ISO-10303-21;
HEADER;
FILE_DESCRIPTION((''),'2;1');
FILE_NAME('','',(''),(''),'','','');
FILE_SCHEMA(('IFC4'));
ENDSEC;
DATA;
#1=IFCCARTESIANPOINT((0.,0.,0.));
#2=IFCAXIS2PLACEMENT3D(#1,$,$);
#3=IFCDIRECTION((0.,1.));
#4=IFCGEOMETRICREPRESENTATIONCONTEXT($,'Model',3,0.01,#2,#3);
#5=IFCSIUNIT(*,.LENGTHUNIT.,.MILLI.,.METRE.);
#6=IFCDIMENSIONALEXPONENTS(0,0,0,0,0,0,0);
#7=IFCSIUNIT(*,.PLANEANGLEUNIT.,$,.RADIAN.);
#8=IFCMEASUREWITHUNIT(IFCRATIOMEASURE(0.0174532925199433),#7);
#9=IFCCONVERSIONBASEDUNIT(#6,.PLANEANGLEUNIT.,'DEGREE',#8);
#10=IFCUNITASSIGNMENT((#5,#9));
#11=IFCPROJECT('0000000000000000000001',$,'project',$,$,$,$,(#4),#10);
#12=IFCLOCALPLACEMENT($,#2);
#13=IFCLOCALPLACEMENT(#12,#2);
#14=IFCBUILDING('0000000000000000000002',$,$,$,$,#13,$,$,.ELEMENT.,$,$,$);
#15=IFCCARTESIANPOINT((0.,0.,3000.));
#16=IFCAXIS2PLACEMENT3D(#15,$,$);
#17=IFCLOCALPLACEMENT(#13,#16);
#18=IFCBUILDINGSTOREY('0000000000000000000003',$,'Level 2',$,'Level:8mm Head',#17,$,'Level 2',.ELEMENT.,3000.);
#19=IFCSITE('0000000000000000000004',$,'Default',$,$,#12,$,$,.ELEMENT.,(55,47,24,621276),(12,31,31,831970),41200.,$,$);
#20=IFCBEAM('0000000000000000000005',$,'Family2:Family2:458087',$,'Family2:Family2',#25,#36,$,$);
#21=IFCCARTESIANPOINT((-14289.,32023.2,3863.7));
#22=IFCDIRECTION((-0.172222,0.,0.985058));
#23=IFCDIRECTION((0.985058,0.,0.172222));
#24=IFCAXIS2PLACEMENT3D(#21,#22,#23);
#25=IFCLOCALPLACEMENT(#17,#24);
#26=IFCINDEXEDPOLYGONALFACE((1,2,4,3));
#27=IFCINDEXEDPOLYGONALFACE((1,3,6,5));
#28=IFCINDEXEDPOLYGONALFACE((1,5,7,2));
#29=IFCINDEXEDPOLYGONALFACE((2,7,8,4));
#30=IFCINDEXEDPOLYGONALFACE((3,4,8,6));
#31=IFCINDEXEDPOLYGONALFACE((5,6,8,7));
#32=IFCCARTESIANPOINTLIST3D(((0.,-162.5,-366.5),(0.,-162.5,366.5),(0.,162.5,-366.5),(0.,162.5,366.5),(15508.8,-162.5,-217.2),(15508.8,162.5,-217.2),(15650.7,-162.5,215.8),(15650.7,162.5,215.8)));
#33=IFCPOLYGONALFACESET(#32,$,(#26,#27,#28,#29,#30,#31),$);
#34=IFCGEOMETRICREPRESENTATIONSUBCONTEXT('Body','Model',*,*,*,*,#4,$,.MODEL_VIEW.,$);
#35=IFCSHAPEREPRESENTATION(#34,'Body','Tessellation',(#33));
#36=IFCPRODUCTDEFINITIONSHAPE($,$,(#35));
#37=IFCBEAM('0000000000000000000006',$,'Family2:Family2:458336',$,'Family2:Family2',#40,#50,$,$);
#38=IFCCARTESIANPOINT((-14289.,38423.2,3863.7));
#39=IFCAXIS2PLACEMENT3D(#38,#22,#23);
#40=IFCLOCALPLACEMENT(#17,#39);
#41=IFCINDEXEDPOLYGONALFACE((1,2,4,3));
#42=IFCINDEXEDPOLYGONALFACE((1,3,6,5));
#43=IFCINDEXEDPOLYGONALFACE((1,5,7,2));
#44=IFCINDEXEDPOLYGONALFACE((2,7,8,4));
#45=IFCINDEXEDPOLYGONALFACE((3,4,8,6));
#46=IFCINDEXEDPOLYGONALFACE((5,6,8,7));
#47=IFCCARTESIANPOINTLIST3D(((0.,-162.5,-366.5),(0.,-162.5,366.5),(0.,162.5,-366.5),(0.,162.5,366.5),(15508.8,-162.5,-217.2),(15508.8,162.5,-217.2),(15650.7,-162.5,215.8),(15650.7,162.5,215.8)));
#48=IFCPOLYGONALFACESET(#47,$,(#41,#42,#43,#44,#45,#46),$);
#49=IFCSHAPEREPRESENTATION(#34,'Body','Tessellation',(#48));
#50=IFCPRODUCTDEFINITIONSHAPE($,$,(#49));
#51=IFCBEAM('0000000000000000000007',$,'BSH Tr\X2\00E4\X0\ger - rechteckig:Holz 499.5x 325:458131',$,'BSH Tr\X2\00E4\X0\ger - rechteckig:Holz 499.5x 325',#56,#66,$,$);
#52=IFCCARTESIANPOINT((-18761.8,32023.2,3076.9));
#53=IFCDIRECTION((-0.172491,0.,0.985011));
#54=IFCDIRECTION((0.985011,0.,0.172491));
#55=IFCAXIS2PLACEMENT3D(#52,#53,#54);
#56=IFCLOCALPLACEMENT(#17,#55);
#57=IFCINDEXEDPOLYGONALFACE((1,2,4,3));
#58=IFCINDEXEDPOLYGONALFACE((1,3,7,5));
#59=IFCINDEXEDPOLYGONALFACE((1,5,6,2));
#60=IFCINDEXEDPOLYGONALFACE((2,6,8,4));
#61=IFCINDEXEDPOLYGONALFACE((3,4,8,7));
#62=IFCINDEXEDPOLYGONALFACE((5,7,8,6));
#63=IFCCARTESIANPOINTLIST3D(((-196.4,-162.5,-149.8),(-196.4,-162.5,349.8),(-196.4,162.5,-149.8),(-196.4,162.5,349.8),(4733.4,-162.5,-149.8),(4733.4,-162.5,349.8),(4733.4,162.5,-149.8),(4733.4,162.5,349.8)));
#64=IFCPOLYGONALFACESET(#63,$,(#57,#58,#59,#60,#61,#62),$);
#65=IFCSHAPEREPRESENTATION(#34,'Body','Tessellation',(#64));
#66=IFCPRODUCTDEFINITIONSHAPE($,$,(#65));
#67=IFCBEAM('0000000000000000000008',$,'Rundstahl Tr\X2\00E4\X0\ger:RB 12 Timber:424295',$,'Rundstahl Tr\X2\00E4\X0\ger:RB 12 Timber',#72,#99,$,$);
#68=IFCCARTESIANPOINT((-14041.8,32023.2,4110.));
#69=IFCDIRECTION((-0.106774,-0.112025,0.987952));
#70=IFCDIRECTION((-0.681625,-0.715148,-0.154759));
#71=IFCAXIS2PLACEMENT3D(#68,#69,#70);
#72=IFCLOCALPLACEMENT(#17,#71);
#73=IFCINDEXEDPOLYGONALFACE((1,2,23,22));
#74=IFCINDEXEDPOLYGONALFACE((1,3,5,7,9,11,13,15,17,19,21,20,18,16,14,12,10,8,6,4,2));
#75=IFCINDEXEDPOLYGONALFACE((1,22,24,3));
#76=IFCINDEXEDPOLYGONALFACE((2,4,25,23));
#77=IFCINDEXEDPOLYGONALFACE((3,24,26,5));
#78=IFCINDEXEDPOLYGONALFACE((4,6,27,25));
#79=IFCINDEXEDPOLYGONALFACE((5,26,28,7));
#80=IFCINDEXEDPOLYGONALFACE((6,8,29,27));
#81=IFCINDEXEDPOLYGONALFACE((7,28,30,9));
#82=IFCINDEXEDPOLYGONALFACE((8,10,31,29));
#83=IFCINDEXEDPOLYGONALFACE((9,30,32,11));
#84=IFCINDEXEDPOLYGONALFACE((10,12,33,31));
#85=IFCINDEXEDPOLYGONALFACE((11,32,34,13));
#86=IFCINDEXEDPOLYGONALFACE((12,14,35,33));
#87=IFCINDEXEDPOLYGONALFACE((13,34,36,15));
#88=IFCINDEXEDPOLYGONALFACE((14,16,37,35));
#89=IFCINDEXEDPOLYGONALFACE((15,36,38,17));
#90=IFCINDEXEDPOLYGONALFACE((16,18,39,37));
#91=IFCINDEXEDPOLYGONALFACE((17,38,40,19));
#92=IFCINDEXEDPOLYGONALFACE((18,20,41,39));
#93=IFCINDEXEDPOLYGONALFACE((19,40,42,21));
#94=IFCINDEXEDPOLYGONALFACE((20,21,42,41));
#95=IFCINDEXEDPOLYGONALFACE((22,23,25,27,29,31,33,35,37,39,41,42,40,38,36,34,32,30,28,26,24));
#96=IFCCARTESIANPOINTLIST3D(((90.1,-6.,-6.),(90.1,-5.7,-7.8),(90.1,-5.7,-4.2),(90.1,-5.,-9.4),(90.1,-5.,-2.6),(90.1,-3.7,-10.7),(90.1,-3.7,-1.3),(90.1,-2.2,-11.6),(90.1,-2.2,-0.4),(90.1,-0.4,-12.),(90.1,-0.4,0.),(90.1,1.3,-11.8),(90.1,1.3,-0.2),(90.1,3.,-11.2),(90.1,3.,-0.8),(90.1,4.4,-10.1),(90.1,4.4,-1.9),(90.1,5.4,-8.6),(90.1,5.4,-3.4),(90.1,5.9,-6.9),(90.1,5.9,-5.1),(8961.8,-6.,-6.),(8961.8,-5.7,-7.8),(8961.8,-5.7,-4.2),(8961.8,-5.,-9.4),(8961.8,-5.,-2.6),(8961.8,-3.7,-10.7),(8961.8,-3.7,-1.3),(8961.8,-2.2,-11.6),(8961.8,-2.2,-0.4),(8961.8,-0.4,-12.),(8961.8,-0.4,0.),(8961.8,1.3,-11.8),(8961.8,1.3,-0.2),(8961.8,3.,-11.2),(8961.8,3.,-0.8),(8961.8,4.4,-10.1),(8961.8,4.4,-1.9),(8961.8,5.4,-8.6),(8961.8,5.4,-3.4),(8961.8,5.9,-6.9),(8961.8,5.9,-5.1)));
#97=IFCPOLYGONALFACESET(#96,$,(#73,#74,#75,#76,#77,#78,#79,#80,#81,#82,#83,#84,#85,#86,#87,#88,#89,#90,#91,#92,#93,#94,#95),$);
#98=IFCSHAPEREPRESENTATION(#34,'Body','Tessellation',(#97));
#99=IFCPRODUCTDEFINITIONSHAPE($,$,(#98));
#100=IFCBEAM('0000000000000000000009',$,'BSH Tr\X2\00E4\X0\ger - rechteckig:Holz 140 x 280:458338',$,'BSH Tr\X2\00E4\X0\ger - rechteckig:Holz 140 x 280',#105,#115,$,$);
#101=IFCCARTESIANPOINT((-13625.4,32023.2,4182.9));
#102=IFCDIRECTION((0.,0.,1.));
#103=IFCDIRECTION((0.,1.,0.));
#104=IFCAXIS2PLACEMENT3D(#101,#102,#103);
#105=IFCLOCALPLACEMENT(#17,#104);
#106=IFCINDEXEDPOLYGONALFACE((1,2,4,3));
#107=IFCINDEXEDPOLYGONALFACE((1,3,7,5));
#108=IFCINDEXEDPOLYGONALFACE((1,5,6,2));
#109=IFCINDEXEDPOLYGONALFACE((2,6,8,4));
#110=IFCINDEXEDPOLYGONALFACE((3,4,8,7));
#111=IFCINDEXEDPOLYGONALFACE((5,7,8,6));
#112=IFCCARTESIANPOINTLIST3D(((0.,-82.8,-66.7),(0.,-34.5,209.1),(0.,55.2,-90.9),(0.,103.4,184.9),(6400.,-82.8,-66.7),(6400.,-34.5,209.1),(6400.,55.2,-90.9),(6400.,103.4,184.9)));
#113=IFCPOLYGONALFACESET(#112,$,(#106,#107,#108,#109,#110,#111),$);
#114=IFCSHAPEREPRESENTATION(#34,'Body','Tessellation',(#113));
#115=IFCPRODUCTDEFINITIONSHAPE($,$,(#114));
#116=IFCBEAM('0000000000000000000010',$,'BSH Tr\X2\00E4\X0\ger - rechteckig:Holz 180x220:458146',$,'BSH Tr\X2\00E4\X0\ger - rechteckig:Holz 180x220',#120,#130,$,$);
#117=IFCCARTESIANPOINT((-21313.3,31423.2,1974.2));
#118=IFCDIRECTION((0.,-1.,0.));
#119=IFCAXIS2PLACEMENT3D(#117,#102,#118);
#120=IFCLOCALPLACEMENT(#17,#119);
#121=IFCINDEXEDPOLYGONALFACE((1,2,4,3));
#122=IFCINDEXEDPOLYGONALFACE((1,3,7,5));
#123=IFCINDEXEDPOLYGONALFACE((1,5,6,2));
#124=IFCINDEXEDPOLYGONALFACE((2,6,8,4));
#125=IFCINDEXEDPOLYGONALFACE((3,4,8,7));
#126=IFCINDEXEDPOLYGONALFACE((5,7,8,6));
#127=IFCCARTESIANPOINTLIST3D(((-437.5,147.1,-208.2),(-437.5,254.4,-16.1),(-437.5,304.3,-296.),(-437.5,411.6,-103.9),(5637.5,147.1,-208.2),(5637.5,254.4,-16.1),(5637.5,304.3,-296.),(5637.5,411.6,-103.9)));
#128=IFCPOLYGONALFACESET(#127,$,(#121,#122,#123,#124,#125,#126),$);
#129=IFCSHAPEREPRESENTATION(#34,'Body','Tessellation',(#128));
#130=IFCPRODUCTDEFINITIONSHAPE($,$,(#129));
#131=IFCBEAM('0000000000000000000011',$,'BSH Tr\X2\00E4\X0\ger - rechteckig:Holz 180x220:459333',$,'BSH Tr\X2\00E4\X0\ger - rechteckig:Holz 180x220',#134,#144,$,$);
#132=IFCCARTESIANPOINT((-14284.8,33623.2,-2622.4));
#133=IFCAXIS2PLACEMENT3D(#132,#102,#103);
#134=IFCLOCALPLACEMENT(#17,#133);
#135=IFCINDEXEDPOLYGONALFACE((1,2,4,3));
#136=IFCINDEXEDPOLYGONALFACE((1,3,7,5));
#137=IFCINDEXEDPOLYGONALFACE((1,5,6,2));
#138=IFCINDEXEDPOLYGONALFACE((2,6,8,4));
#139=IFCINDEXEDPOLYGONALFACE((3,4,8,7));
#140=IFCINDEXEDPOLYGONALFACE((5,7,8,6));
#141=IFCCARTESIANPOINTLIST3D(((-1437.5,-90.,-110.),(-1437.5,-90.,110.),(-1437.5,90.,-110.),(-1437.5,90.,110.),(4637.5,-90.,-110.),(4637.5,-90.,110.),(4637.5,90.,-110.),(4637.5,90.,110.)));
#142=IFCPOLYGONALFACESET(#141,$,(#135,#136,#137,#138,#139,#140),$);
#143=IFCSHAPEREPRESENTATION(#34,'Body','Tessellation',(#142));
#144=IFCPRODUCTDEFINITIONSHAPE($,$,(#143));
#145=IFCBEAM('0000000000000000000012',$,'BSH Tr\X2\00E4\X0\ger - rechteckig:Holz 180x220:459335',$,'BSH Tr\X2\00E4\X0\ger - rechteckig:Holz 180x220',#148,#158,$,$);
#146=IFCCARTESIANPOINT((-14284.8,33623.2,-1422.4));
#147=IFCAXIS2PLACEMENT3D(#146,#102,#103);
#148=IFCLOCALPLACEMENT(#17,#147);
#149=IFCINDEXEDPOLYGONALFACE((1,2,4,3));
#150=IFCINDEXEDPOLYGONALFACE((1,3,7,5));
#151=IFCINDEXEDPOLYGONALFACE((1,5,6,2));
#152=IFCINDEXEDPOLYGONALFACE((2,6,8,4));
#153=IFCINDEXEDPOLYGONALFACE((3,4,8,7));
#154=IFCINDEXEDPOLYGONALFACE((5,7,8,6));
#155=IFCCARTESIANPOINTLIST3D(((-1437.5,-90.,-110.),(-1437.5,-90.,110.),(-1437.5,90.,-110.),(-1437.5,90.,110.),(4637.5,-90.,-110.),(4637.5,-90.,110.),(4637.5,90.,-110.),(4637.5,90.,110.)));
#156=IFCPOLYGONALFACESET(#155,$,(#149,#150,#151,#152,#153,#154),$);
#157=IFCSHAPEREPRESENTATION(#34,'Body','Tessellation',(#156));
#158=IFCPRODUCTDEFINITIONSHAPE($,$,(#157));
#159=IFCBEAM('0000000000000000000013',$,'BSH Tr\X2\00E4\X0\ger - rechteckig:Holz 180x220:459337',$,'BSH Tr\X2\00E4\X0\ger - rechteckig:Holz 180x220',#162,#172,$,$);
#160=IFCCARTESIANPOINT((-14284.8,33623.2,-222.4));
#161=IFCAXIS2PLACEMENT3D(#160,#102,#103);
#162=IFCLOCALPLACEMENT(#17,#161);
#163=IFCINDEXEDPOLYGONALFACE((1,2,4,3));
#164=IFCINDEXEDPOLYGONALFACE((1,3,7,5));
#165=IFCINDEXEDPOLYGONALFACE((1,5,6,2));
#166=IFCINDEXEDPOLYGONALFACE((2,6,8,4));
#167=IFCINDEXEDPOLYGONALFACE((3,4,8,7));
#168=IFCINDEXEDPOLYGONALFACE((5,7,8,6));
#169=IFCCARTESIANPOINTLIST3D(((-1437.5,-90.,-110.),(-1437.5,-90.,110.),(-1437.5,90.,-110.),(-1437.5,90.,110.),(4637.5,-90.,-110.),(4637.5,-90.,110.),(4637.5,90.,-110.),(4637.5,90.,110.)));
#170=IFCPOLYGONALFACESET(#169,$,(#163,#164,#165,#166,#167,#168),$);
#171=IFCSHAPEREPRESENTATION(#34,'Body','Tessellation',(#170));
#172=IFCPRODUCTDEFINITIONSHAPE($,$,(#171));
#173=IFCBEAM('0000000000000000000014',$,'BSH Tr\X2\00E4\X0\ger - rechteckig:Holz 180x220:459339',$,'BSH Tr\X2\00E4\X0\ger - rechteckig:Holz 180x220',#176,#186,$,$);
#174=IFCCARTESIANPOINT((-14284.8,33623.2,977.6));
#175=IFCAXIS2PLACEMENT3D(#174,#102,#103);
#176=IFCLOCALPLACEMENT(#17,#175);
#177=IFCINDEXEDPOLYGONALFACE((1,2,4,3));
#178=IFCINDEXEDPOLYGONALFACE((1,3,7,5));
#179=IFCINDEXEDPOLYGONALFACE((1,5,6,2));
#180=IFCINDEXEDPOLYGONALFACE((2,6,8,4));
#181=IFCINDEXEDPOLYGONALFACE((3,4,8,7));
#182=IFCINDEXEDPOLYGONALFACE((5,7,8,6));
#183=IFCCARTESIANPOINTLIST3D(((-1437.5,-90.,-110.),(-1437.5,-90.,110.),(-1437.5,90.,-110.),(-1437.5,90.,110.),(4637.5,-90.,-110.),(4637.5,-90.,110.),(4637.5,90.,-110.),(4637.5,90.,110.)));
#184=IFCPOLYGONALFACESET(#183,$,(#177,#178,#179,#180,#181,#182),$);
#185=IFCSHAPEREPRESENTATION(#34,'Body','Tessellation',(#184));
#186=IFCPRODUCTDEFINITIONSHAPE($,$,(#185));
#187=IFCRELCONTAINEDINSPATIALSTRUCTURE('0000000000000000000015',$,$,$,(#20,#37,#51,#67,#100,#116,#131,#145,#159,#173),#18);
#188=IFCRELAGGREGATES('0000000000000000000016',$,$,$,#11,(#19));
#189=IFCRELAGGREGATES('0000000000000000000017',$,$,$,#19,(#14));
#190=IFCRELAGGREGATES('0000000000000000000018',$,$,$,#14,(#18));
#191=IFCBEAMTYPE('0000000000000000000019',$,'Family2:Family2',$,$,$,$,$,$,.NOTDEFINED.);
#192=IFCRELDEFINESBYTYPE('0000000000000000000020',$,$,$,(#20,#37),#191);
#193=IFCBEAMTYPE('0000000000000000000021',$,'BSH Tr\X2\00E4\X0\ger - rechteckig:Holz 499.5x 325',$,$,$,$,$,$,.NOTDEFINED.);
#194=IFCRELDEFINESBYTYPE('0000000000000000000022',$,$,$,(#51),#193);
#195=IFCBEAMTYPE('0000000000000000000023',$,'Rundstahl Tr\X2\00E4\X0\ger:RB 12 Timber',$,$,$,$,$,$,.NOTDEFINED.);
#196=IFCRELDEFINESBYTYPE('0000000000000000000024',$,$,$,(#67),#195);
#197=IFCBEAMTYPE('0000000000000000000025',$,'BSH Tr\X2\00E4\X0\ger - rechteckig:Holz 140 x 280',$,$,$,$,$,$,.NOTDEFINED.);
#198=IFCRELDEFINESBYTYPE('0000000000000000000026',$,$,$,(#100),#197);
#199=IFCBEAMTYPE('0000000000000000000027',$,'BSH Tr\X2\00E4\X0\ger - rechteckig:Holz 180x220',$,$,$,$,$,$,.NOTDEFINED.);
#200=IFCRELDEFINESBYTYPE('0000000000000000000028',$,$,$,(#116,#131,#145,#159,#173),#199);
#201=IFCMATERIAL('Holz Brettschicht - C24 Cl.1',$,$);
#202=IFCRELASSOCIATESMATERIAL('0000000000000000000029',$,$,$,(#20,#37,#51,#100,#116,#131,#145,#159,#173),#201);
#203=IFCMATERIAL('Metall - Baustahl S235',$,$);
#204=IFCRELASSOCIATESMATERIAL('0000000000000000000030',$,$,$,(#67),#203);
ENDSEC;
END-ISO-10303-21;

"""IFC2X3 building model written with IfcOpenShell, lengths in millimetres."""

from ifc_helpers import new_model, entity, si_unit, converted_unit, direction, frame, frame_2d, origin, origin_2d_with_axis, place, context, subcontext, project, spatial, polyline, rectangle, circle, extrude, clip, bounded_halfspace, material, type_object, element, save


model = new_model("IFC2X3")

# Units and contexts
model_context = context("Model", 3, precision=0.01, world=origin(), true_north=direction((0.0, 1.0)))
body_context = subcontext(model_context, "Body", "Model", "MODEL_VIEW")
ifc_project = project(units=[si_unit("LENGTHUNIT", "METRE", prefix="MILLI"), converted_unit("PLANEANGLEUNIT", "DEGREE", entity("IfcRatioMeasure", 0.0174532925199433), si_unit("PLANEANGLEUNIT", "RADIAN"), dimensions=[0, 0, 0, 0, 0, 0, 0])], contexts=[model_context])

# Site, building, storey
site_placement = place(None, origin())
site = spatial("IfcSite", under=ifc_project, at=site_placement, Name="Default", CompositionType="ELEMENT", RefLatitude=(55, 47, 24, 621276), RefLongitude=(12, 31, 31, 831970), RefElevation=41200.0)
building_placement = place(site_placement, origin())
building = spatial("IfcBuilding", under=site, at=building_placement, CompositionType="ELEMENT")
storey_placement = place(building_placement, frame((0.0, 0.0, 3000.0)))
storey = spatial("IfcBuildingStorey", under=building, at=storey_placement, Name="Level 2", ObjectType="Level:8mm Head", LongName="Level 2", CompositionType="ELEMENT", Elevation=3000.0)

# Beams
ifc_material_1 = material(Name="Holz Brettschicht - C24 Cl.1")
beam_type_1 = type_object("IfcBeamType", Name="Family2:Family2", PredefinedType="NOTDEFINED")
beam_1_placement = place(storey_placement, frame((-14289.0, 32023.2, 3863.7), z_axis=(-0.172222, 0.0, 0.985058), x_axis=(0.985058, 0.0, 0.172222)))
element("IfcBeam", 1, at=beam_1_placement, inside=storey, type_object=beam_type_1, material=ifc_material_1, Name="Family2:Family2:458087", ObjectType="Family2:Family2", context=body_context, shape_type="Clipping", body=[
    clip(clip(clip(extrude(rectangle(XDim=733.0, YDim=325.0, at=frame_2d((0.0, 0.0), x_axis=(0.0, 1.0))), frame((0.0, 0.0, 0.0), z_axis=(1.0, 0.0, 0.0), x_axis=(0.0, 1.0, 0.0)), (0.0, 0.0, 1.0), 15650.7), bounded_halfspace(frame((0.0, 0.0, -366.5), z_axis=(0.009627, 0.0, -0.999954), x_axis=(0.0, 1.0, 0.0)), False, frame((0.0, 0.0, 0.0), z_axis=(1.0, 0.0, 0.0), x_axis=(0.0, 1.0, 0.0)), polyline([(-162.5, -366.5), (162.5, -366.5), (162.5, -217.2), (-162.5, -217.2), (-162.5, -366.5)]))), bounded_halfspace(frame((15700.1, 0.0, 366.5), z_axis=(0.95028, 0.0, -0.311395), x_axis=(0.311395, 0.0, 0.95028)), False, frame((0.0, 0.0, 0.0), z_axis=(1.0, 0.0, 0.0), x_axis=(0.0, 1.0, 0.0)), polyline([(-162.5, 215.8), (-162.5, -217.2), (162.5, -217.2), (162.5, 215.8), (-162.5, 215.8)]))), bounded_halfspace(frame((0.0, 0.0, 366.5), z_axis=(0.009627, 0.0, 0.999954), x_axis=(0.0, -1.0, 0.0)), False, frame((0.0, 0.0, 0.0), z_axis=(1.0, 0.0, 0.0), x_axis=(0.0, 1.0, 0.0)), polyline([(162.5, 366.5), (-162.5, 366.5), (-162.5, 215.8), (162.5, 215.8), (162.5, 366.5)]))),
])
beam_2_placement = place(storey_placement, frame((-14289.0, 38423.2, 3863.7), z_axis=(-0.172222, 0.0, 0.985058), x_axis=(0.985058, 0.0, 0.172222)))
element("IfcBeam", 2, at=beam_2_placement, inside=storey, type_object=beam_type_1, material=ifc_material_1, Name="Family2:Family2:458336", ObjectType="Family2:Family2", context=body_context, shape_type="Clipping", body=[
    clip(clip(clip(extrude(rectangle(XDim=733.0, YDim=325.0, at=frame_2d((0.0, 0.0), x_axis=(0.0, 1.0))), frame((0.0, 0.0, 0.0), z_axis=(1.0, 0.0, 0.0), x_axis=(0.0, 1.0, 0.0)), (0.0, 0.0, 1.0), 15650.7), bounded_halfspace(frame((0.0, 0.0, -366.5), z_axis=(0.009627, 0.0, -0.999954), x_axis=(0.0, 1.0, 0.0)), False, frame((0.0, 0.0, 0.0), z_axis=(1.0, 0.0, 0.0), x_axis=(0.0, 1.0, 0.0)), polyline([(-162.5, -366.5), (162.5, -366.5), (162.5, -217.2), (-162.5, -217.2), (-162.5, -366.5)]))), bounded_halfspace(frame((15700.1, 0.0, 366.5), z_axis=(0.95028, 0.0, -0.311395), x_axis=(0.311395, 0.0, 0.95028)), False, frame((0.0, 0.0, 0.0), z_axis=(1.0, 0.0, 0.0), x_axis=(0.0, 1.0, 0.0)), polyline([(-162.5, 215.8), (-162.5, -217.2), (162.5, -217.2), (162.5, 215.8), (-162.5, 215.8)]))), bounded_halfspace(frame((0.0, 0.0, 366.5), z_axis=(0.009627, 0.0, 0.999954), x_axis=(0.0, -1.0, 0.0)), False, frame((0.0, 0.0, 0.0), z_axis=(1.0, 0.0, 0.0), x_axis=(0.0, 1.0, 0.0)), polyline([(162.5, 366.5), (-162.5, 366.5), (-162.5, 215.8), (162.5, 215.8), (162.5, 366.5)]))),
])
beam_type_2 = type_object("IfcBeamType", Name="BSH Träger - rechteckig:Holz 499.5x 325", PredefinedType="NOTDEFINED")
beam_3_placement = place(storey_placement, frame((-18761.8, 32023.2, 3076.9), z_axis=(-0.172491, 0.0, 0.985011), x_axis=(0.985011, 0.0, 0.172491)))
element("IfcBeam", 3, at=beam_3_placement, inside=storey, type_object=beam_type_2, material=ifc_material_1, Name="BSH Träger - rechteckig:Holz 499.5x 325:458131", ObjectType="BSH Träger - rechteckig:Holz 499.5x 325", context=body_context, shape_type="SweptSolid", body=[
    extrude(rectangle(XDim=499.5, YDim=325.0, at=frame_2d((0.0, 0.0), x_axis=(1.0, 0.0))), frame((-196.4, 0.0, 100.0), z_axis=(1.0, 0.0, 0.0), x_axis=(0.0, 0.0, -1.0)), (0.0, 0.0, 1.0), 4929.8),
])
ifc_material_2 = material(Name="Metall - Baustahl S235")
beam_type_3 = type_object("IfcBeamType", Name="Rundstahl Träger:RB 12 Timber", PredefinedType="NOTDEFINED")
beam_4_placement = place(storey_placement, frame((-14041.8, 32023.2, 4110.0), z_axis=(-0.106774, -0.112025, 0.987952), x_axis=(-0.681625, -0.715148, -0.154759)))
element("IfcBeam", 4, at=beam_4_placement, inside=storey, type_object=beam_type_3, material=ifc_material_2, Name="Rundstahl Träger:RB 12 Timber:424295", ObjectType="Rundstahl Träger:RB 12 Timber", context=body_context, shape_type="SweptSolid", body=[
    extrude(circle(Radius=6.0, at=frame_2d((0.0, 0.0), x_axis=(1.0, 0.0))), frame((90.1, 0.0, -6.0), z_axis=(1.0, 0.0, 0.0), x_axis=(0.0, -1.0, 0.0)), (0.0, 0.0, 1.0), 8871.7),
])
beam_type_4 = type_object("IfcBeamType", Name="BSH Träger - rechteckig:Holz 140 x 280", PredefinedType="NOTDEFINED")
beam_5_placement = place(storey_placement, frame((-13625.4, 32023.2, 4182.9), z_axis=(0.0, 0.0, 1.0), x_axis=(0.0, 1.0, 0.0)))
element("IfcBeam", 5, at=beam_5_placement, inside=storey, type_object=beam_type_4, material=ifc_material_1, Name="BSH Träger - rechteckig:Holz 140 x 280:458338", ObjectType="BSH Träger - rechteckig:Holz 140 x 280", context=body_context, shape_type="SweptSolid", body=[
    extrude(rectangle(XDim=280.0, YDim=140.0, at=origin_2d_with_axis()), frame((0.0, 10.3, 59.1), z_axis=(1.0, 0.0, 0.0), x_axis=(0.0, 0.172491, 0.985011)), (0.0, 0.0, 1.0), 6400.0),
])
beam_type_5 = type_object("IfcBeamType", Name="BSH Träger - rechteckig:Holz 180x220", PredefinedType="NOTDEFINED")
beam_6_placement = place(storey_placement, frame((-21313.3, 31423.2, 1974.2), z_axis=(0.0, 0.0, 1.0), x_axis=(0.0, -1.0, 0.0)))
element("IfcBeam", 6, at=beam_6_placement, inside=storey, type_object=beam_type_5, material=ifc_material_1, Name="BSH Träger - rechteckig:Holz 180x220:458146", ObjectType="BSH Träger - rechteckig:Holz 180x220", context=body_context, shape_type="SweptSolid", body=[
    extrude(rectangle(XDim=220.0, YDim=180.0, at=frame_2d((0.0, 0.0), x_axis=(1.0, 0.0))), frame((-437.5, 279.4, -156.1), z_axis=(1.0, 0.0, 0.0), x_axis=(0.0, 0.4877, 0.873011)), (0.0, 0.0, 1.0), 6075.0),
])
beam_7_placement = place(storey_placement, frame((-14284.8, 33623.2, -2622.4), z_axis=(0.0, 0.0, 1.0), x_axis=(0.0, 1.0, 0.0)))
element("IfcBeam", 7, at=beam_7_placement, inside=storey, type_object=beam_type_5, material=ifc_material_1, Name="BSH Träger - rechteckig:Holz 180x220:459333", ObjectType="BSH Träger - rechteckig:Holz 180x220", context=body_context, shape_type="SweptSolid", body=[
    extrude(rectangle(XDim=220.0, YDim=180.0, at=frame_2d((0.0, 0.0), x_axis=(1.0, 0.0))), frame((-1437.5, 0.0, 0.0), z_axis=(1.0, 0.0, 0.0), x_axis=(0.0, 0.0, -1.0)), (0.0, 0.0, 1.0), 6075.0),
])
beam_8_placement = place(storey_placement, frame((-14284.8, 33623.2, -1422.4), z_axis=(0.0, 0.0, 1.0), x_axis=(0.0, 1.0, 0.0)))
element("IfcBeam", 8, at=beam_8_placement, inside=storey, type_object=beam_type_5, material=ifc_material_1, Name="BSH Träger - rechteckig:Holz 180x220:459335", ObjectType="BSH Träger - rechteckig:Holz 180x220", context=body_context, shape_type="SweptSolid", body=[
    extrude(rectangle(XDim=220.0, YDim=180.0, at=frame_2d((0.0, 0.0), x_axis=(1.0, 0.0))), frame((-1437.5, 0.0, 0.0), z_axis=(1.0, 0.0, 0.0), x_axis=(0.0, 0.0, -1.0)), (0.0, 0.0, 1.0), 6075.0),
])
for number, where, z_axis, x_axis, name in (
    (9, (-14284.8, 33623.2, -222.4), (0.0, 0.0, 1.0), (0.0, 1.0, 0.0), "BSH Träger - rechteckig:Holz 180x220:459337"),
    (10, (-14284.8, 33623.2, 977.6), (0.0, 0.0, 1.0), (0.0, 1.0, 0.0), "BSH Träger - rechteckig:Holz 180x220:459339"),
):
    element("IfcBeam", number, at=place(storey_placement, frame(where, z_axis=z_axis, x_axis=x_axis)), inside=storey, type_object=beam_type_5, material=ifc_material_1, Name=name, ObjectType="BSH Träger - rechteckig:Holz 180x220", context=body_context, shape_type="SweptSolid", body=[
        extrude(rectangle(XDim=220.0, YDim=180.0, at=frame_2d((0.0, 0.0), x_axis=(1.0, 0.0))), frame((-1437.5, 0.0, 0.0), z_axis=(1.0, 0.0, 0.0), x_axis=(0.0, 0.0, -1.0)), (0.0, 0.0, 1.0), 6075.0),
    ])

save(model, "model.ifc")
